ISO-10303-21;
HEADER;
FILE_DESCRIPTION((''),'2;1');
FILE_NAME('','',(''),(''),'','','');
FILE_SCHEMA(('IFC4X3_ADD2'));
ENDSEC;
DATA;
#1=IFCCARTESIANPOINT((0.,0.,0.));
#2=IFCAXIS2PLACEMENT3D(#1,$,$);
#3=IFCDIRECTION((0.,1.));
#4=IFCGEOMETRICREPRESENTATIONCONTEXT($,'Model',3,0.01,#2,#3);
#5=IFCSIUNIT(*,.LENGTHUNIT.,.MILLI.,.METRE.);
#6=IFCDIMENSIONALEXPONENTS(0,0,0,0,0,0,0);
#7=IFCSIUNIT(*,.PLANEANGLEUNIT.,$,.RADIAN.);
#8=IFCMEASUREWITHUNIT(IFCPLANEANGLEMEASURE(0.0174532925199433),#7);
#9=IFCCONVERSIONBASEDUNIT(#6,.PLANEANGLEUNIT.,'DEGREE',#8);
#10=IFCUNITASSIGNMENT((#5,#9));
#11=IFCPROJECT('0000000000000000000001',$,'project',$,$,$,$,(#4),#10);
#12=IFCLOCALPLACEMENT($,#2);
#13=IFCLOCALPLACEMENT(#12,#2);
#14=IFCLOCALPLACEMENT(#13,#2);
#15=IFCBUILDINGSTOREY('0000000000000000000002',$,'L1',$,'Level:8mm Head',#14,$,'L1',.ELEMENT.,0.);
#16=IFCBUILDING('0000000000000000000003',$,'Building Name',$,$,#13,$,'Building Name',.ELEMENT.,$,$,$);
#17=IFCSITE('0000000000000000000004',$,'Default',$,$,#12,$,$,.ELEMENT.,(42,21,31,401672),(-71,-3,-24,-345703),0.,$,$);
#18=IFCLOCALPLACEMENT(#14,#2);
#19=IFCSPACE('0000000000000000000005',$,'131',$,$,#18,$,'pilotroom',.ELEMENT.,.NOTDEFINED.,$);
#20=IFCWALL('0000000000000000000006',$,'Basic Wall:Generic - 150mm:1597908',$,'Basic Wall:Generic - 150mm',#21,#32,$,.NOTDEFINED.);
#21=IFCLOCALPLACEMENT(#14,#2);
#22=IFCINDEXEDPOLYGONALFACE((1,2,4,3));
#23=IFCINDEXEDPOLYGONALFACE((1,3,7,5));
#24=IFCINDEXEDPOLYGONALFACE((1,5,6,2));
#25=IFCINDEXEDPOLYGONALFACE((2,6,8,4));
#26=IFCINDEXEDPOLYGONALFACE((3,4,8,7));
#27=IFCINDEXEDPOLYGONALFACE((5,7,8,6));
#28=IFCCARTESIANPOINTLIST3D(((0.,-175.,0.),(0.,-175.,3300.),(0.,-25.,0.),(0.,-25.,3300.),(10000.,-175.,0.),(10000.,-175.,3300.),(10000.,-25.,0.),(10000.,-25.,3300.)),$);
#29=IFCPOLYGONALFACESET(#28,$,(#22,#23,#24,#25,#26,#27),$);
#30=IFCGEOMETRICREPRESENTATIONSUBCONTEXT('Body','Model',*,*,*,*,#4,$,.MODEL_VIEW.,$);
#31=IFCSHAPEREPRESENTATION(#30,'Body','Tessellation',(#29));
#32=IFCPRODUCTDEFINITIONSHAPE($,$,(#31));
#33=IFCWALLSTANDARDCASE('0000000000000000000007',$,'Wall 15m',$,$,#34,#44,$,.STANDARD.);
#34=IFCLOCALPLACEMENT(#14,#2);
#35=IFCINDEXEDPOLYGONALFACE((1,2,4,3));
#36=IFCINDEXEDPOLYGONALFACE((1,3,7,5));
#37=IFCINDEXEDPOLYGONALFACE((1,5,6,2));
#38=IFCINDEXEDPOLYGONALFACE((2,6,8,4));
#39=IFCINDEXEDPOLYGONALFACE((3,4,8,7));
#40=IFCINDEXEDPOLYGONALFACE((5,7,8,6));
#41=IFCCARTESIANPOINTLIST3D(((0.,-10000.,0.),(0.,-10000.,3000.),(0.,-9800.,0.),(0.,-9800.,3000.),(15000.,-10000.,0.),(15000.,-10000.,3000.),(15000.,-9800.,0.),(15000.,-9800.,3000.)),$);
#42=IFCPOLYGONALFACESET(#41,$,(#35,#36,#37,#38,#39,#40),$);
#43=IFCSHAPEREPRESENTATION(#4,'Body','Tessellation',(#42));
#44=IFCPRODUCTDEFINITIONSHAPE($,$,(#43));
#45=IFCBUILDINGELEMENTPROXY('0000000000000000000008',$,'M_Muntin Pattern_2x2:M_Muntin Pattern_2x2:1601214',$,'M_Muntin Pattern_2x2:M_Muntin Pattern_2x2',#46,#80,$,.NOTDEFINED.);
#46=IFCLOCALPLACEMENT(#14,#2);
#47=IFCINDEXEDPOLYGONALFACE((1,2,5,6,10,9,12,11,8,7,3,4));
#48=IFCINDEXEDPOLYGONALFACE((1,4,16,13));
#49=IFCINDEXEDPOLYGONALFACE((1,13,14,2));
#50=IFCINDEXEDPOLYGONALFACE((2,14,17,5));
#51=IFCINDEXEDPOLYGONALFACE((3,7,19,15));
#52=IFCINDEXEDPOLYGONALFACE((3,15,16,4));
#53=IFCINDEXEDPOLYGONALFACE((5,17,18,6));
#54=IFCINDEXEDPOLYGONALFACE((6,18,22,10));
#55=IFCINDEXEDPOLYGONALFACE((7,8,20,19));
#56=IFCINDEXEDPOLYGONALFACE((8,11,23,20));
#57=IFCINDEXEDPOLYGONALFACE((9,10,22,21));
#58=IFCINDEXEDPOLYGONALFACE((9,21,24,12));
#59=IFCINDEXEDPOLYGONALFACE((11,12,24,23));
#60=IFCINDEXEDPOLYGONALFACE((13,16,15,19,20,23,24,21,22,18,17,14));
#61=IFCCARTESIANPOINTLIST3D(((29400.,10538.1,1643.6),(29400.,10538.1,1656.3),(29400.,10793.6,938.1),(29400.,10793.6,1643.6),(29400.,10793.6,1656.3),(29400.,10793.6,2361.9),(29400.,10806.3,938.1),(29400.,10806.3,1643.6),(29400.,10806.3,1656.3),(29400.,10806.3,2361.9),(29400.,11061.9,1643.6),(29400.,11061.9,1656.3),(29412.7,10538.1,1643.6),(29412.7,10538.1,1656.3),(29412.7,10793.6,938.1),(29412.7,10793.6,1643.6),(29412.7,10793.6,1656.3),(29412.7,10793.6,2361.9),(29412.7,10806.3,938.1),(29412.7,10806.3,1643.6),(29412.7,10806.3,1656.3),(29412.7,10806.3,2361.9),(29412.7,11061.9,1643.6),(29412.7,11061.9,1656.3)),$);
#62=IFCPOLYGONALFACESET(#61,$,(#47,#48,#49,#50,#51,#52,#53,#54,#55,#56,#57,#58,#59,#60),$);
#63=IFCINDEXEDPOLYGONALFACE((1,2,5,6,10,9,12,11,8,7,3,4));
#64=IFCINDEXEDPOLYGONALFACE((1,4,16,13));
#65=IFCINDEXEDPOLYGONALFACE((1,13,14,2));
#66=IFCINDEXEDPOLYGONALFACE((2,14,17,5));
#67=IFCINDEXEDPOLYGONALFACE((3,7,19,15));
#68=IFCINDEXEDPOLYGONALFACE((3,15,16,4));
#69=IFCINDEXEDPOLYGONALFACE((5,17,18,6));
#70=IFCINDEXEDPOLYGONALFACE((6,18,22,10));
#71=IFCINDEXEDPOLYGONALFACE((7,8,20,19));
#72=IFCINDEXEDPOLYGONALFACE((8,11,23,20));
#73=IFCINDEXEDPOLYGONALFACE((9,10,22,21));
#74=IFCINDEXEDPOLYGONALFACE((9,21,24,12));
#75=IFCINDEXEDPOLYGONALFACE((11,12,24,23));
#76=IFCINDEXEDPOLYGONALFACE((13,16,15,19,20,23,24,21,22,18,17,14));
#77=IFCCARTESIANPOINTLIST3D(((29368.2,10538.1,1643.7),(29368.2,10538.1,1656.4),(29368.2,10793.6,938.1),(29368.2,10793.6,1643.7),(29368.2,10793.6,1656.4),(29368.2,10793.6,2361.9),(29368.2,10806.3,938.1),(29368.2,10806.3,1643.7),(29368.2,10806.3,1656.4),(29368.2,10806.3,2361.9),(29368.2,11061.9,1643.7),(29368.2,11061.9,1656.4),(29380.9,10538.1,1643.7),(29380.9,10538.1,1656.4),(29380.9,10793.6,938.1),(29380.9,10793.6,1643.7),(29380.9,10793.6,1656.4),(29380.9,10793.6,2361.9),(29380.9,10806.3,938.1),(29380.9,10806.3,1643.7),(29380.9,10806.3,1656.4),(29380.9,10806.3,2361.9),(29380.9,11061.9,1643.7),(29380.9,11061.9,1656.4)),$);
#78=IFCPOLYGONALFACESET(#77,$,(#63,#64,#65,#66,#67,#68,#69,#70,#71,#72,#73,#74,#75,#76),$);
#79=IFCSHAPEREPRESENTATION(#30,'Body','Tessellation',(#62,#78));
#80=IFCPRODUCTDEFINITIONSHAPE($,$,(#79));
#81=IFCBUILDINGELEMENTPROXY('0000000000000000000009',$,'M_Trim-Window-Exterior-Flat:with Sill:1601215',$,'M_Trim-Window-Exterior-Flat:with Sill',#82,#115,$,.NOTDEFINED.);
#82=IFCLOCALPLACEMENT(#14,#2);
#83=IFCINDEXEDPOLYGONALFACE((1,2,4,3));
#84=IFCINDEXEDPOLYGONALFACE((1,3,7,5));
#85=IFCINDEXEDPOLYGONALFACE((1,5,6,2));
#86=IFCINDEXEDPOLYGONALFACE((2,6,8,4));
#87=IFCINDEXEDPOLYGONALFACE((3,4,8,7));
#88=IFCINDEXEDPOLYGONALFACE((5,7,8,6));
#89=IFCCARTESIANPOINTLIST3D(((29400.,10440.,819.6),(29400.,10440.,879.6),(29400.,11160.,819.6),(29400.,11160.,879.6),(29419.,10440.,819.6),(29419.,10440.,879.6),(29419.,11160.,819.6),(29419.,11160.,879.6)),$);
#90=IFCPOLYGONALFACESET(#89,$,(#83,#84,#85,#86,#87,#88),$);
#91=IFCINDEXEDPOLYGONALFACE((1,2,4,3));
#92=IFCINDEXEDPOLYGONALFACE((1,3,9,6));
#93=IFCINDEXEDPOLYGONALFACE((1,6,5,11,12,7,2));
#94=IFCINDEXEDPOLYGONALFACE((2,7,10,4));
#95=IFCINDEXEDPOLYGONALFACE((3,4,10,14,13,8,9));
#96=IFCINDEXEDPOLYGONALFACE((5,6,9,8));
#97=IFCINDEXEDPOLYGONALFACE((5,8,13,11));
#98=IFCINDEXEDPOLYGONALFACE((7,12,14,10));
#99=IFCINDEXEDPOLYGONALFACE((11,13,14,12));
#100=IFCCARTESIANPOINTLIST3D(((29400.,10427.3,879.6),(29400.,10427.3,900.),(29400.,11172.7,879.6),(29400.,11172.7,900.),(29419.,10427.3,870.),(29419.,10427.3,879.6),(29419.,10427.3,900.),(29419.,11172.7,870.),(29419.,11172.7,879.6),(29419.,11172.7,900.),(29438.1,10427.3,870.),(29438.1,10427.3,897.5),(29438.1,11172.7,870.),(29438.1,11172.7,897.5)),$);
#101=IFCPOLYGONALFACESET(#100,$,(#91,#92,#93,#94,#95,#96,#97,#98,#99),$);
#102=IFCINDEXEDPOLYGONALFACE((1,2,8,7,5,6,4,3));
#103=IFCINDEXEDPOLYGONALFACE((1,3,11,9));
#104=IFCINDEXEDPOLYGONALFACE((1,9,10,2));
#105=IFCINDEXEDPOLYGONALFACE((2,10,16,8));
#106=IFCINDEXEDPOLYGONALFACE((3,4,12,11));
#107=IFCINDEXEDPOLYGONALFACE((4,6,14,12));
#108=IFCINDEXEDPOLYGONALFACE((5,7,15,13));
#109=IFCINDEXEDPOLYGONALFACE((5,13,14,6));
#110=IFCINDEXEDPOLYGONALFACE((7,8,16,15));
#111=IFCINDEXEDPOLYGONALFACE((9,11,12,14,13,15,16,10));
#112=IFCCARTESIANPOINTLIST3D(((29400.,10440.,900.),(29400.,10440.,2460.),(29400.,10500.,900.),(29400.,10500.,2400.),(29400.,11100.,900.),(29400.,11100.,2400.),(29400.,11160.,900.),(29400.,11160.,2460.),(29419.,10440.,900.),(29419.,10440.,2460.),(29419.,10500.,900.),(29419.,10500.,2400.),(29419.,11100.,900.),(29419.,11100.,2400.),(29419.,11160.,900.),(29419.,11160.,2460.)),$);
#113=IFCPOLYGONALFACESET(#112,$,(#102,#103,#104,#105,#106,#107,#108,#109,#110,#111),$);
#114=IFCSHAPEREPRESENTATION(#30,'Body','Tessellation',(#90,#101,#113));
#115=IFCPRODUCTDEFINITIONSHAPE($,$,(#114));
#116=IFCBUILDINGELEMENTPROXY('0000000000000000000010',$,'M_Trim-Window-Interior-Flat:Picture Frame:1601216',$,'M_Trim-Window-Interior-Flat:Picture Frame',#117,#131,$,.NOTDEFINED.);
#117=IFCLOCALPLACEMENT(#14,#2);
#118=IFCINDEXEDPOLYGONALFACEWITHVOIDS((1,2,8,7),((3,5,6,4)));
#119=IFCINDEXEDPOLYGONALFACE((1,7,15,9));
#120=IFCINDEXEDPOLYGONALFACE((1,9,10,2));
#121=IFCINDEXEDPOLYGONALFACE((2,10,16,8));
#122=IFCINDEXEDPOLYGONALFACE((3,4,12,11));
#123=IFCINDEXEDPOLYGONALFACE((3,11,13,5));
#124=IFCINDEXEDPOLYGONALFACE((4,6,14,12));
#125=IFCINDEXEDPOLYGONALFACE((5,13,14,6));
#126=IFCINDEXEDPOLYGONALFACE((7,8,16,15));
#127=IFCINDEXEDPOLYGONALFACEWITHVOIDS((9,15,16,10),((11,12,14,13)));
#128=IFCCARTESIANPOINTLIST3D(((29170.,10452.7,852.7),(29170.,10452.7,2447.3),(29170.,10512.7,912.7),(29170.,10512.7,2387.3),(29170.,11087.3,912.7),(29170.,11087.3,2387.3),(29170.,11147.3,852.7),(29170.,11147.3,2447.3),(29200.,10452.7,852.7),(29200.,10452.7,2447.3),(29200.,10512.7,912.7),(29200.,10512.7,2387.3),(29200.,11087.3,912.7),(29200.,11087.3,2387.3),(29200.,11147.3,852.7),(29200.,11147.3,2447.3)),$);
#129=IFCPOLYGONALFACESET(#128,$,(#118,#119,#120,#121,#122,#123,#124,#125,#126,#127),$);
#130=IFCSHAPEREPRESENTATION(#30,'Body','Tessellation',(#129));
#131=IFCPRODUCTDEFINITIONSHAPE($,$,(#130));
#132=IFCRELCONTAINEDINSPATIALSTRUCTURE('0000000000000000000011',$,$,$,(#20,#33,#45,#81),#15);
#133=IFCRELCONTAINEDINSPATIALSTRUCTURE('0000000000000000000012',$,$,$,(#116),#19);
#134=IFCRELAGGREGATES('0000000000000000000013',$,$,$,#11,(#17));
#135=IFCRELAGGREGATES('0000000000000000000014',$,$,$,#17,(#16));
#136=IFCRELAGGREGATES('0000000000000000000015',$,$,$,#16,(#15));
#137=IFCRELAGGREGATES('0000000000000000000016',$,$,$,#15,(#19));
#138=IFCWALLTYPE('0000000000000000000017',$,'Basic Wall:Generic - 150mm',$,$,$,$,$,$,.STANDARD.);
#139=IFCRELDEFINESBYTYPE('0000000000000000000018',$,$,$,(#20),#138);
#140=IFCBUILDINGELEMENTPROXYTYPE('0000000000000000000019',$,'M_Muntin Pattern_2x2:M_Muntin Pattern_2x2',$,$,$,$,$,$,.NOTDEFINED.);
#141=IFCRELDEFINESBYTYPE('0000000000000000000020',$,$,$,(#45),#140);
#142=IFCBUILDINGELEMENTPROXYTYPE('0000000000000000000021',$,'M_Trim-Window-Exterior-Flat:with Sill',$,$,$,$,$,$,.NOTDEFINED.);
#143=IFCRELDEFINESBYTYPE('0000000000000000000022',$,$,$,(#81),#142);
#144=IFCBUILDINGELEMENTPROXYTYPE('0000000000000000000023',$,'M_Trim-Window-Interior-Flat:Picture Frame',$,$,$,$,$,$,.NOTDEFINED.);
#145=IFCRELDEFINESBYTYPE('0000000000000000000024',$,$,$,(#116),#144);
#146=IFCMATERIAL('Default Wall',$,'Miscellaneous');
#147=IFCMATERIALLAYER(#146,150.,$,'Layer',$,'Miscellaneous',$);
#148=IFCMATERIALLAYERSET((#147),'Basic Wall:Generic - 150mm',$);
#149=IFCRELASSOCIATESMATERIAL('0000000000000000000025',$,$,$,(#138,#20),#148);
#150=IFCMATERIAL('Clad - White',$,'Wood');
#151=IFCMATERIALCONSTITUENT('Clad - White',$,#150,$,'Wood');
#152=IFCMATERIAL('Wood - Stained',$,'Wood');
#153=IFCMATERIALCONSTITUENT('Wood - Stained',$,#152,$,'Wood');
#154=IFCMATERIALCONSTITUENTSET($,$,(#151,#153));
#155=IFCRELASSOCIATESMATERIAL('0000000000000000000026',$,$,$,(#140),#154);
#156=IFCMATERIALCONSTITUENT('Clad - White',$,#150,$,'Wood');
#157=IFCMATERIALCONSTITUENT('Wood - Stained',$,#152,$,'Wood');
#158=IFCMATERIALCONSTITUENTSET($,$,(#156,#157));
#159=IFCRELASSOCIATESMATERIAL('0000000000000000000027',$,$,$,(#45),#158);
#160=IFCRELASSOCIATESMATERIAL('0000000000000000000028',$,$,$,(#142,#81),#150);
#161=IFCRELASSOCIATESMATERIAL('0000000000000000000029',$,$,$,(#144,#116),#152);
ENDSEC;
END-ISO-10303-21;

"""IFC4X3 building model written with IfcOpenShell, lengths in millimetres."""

from ifc_helpers import new_model, entity, si_unit, converted_unit, direction, frame, frame_2d, origin, origin_with_axes, place, context, subcontext, project, spatial, polyline, indexed_curve, rectangle, outline, extrude, shape, source, transform, mapped, material, layer, layer_set, constituent, constituent_set, type_object, type_shapes, element, save


model = new_model("IFC4X3")

# Units and contexts
model_context = context("Model", 3, precision=0.01, world=origin(), true_north=direction((0.0, 1.0)))
body_context = subcontext(model_context, "Body", "Model", "MODEL_VIEW")
ifc_project = project(units=[si_unit("LENGTHUNIT", "METRE", prefix="MILLI"), converted_unit("PLANEANGLEUNIT", "DEGREE", entity("IfcPlaneAngleMeasure", 0.0174532925199433), si_unit("PLANEANGLEUNIT", "RADIAN"), dimensions=[0, 0, 0, 0, 0, 0, 0])], contexts=[model_context])

# Site, building, storey
site_placement = place(None, origin())
site = spatial("IfcSite", under=ifc_project, at=site_placement, Name="Default", CompositionType="ELEMENT", RefLatitude=(42, 21, 31, 401672), RefLongitude=(-71, -3, -24, -345703), RefElevation=0.0)
building_placement = place(site_placement, origin())
building = spatial("IfcBuilding", under=site, at=building_placement, Name="Building Name", LongName="Building Name", CompositionType="ELEMENT")
storey_placement = place(building_placement, origin())
storey = spatial("IfcBuildingStorey", under=building, at=storey_placement, Name="L1", ObjectType="Level:8mm Head", LongName="L1", CompositionType="ELEMENT", Elevation=0.0)

# Shared definitions
ifc_material_1 = material(Name="Default Wall", Category="Miscellaneous")

# Walls
ifc_layer_1 = layer(ifc_material_1, 150.0, Name="Layer", Category="Miscellaneous")
ifc_layer_set_1 = layer_set([ifc_layer_1], Name="Basic Wall:Generic - 150mm")
wall_type_1 = type_object("IfcWallType", Name="Basic Wall:Generic - 150mm", PredefinedType="STANDARD", material=ifc_layer_set_1)
wall_1_placement = place(storey_placement, frame((0.0, -100.0, 0.0)))
element("IfcWall", 1, at=wall_1_placement, inside=storey, type_object=wall_type_1, material=ifc_layer_set_1, Name="Basic Wall:Generic - 150mm:1597908", ObjectType="Basic Wall:Generic - 150mm", PredefinedType="NOTDEFINED", context=body_context, shape_type="SweptSolid", body=[
    extrude(rectangle(XDim=10000.0, YDim=150.0, at=frame_2d((5000.0, 0.0), x_axis=(-1.0, 0.0))), origin(), (0.0, 0.0, 1.0), 3300.0),
])
wall_2_placement = place(storey_placement, frame((0.0, -10000.0, 0.0), z_axis=(0.0, 0.0, 1.0), x_axis=(1.0, 0.0, 0.0)))
element("IfcWallStandardCase", 2, at=wall_2_placement, inside=storey, Name="Wall 15m", PredefinedType="STANDARD", shapes=[
    shape(model_context, None, "SweptSolid", [extrude(outline(indexed_curve([(0.0, 0.0), (0.0, 200.0), (15000.0, 200.0), (15000.0, 0.0), (0.0, 0.0)], self_intersect=False)), origin_with_axes(), (0.0, 0.0, 1.0), 3000.0)]),
])

# Building element proxies
ifc_material_2 = material(Name="Clad - White", Category="Wood")
ifc_constituent_1 = constituent(ifc_material_2, Name="Clad - White", Category="Wood")
ifc_material_3 = material(Name="Wood - Stained", Category="Wood")
ifc_constituent_2 = constituent(ifc_material_3, Name="Wood - Stained", Category="Wood")
ifc_constituent_set_1 = constituent_set(constituents=[ifc_constituent_1, ifc_constituent_2])
ifc_constituent_3 = constituent(ifc_material_2, Name="Clad - White", Category="Wood")
ifc_constituent_4 = constituent(ifc_material_3, Name="Wood - Stained", Category="Wood")
ifc_constituent_set_2 = constituent_set(constituents=[ifc_constituent_3, ifc_constituent_4])
building_element_proxy_type_1 = type_object("IfcBuildingElementProxyType", Name="M_Muntin Pattern_2x2:M_Muntin Pattern_2x2", PredefinedType="NOTDEFINED", material=ifc_constituent_set_2)
shared_shape_1 = source(origin(), body_context, "Body", "SweptSolid", [
    extrude(outline(polyline([(6.4, -6.4), (711.9, -6.4), (711.9, 6.3), (6.4, 6.3), (6.4, 261.9), (-6.3, 261.9), (-6.3, 6.3), (-711.9, 6.3), (-711.9, -6.4), (-6.3, -6.4), (-6.3, -261.9), (6.4, -261.9), (6.4, -6.4)])), frame((0.0, -22.2, 711.9), z_axis=(0.0, 1.0, 0.0), x_axis=(0.0, 0.0, 1.0)), (0.0, 0.0, 1.0), 12.7),
    extrude(outline(polyline([(6.4, -6.4), (711.9, -6.4), (711.9, 6.3), (6.4, 6.3), (6.4, 261.9), (-6.3, 261.9), (-6.3, 6.3), (-711.9, 6.3), (-711.9, -6.4), (-6.3, -6.4), (-6.3, -261.9), (6.4, -261.9), (6.4, -6.4)])), frame((0.0, 9.5, 711.9), z_axis=(0.0, 1.0, 0.0), x_axis=(0.0, 0.0, 1.0)), (0.0, 0.0, 1.0), 12.7),
])
type_shapes(building_element_proxy_type_1, [shared_shape_1])
proxy_1_placement = place(storey_placement, frame((29390.5, 10800.0, 938.1), z_axis=(0.0, 0.0, 1.0), x_axis=(0.0, 1.0, 0.0)))
element("IfcBuildingElementProxy", 3, at=proxy_1_placement, inside=storey, type_object=building_element_proxy_type_1, material=ifc_constituent_set_1, Name="M_Muntin Pattern_2x2:M_Muntin Pattern_2x2:1601214", ObjectType="M_Muntin Pattern_2x2:M_Muntin Pattern_2x2", PredefinedType="NOTDEFINED", context=body_context, shape_type="MappedRepresentation", body=[
    mapped(shared_shape_1, transform((0.0, 0.0, 0.0), scale=1.0)),
])
building_element_proxy_type_2 = type_object("IfcBuildingElementProxyType", Name="M_Trim-Window-Exterior-Flat:with Sill", PredefinedType="NOTDEFINED", material=ifc_material_2)
shared_shape_2 = source(origin(), body_context, "Body", "SweptSolid", [
    extrude(rectangle(XDim=720.0, YDim=60.0, at=frame_2d((0.0, 0.0), x_axis=(1.0, 0.0))), frame((0.0, -1550.4, 0.0), z_axis=(0.0, 0.0, 1.0), x_axis=(-1.0, 0.0, 0.0)), (0.0, 0.0, 1.0), 19.1),
    extrude(outline(polyline([(-19.0, -15.2), (0.0, -15.2), (0.0, -5.7), (19.0, -5.7), (19.0, 14.8), (0.0, 14.8), (-19.0, 12.3), (-19.0, -15.2)])), frame((-372.7, -1514.8, 19.0), z_axis=(1.0, 0.0, 0.0), x_axis=(0.0, 0.0, -1.0)), (0.0, 0.0, 1.0), 745.4),
    extrude(outline(polyline([(-795.0, -360.0), (765.0, -360.0), (765.0, -300.0), (-735.0, -300.0), (-735.0, 300.0), (765.0, 300.0), (765.0, 360.0), (-795.0, 360.0), (-795.0, -360.0)])), frame((0.0, -735.0, 0.0), z_axis=(0.0, 0.0, 1.0), x_axis=(0.0, -1.0, 0.0)), (0.0, 0.0, 1.0), 19.1),
])
type_shapes(building_element_proxy_type_2, [shared_shape_2])
proxy_2_placement = place(storey_placement, frame((29400.0, 10800.0, 2400.0), z_axis=(1.0, 0.0, 0.0), x_axis=(0.0, 1.0, 0.0)))
element("IfcBuildingElementProxy", 4, at=proxy_2_placement, inside=storey, type_object=building_element_proxy_type_2, material=ifc_material_2, Name="M_Trim-Window-Exterior-Flat:with Sill:1601215", ObjectType="M_Trim-Window-Exterior-Flat:with Sill", PredefinedType="NOTDEFINED", context=body_context, shape_type="MappedRepresentation", body=[
    mapped(shared_shape_2, transform((0.0, 0.0, 0.0), scale=1.0)),
])

# Shared definitions
space_placement = place(storey_placement, origin())
space = spatial("IfcSpace", under=storey, at=space_placement, Name="131", LongName="pilotroom", CompositionType="ELEMENT", PredefinedType="NOTDEFINED")

# Building element proxy
building_element_proxy_type_3 = type_object("IfcBuildingElementProxyType", Name="M_Trim-Window-Interior-Flat:Picture Frame", PredefinedType="NOTDEFINED", material=ifc_material_3)
shared_shape_3 = source(origin(), body_context, "Body", "SweptSolid", [
    extrude(outline(polyline([(-347.3, -797.3), (347.3, -797.3), (347.3, 797.3), (-347.3, 797.3), (-347.3, -797.3)]), holes=[polyline([(-287.3, -737.3), (-287.3, 737.3), (287.3, 737.3), (287.3, -737.3), (-287.3, -737.3)])]), frame((0.0, -750.0, 0.0), z_axis=(0.0, 0.0, 1.0), x_axis=(-1.0, 0.0, 0.0)), (0.0, 0.0, 1.0), 30.0),
])
type_shapes(building_element_proxy_type_3, [shared_shape_3])
proxy_3_placement = place(space_placement, frame((29200.0, 10800.0, 2400.0), z_axis=(-1.0, 0.0, 0.0), x_axis=(0.0, -1.0, 0.0)))
element("IfcBuildingElementProxy", 5, at=proxy_3_placement, inside=space, type_object=building_element_proxy_type_3, material=ifc_material_3, Name="M_Trim-Window-Interior-Flat:Picture Frame:1601216", ObjectType="M_Trim-Window-Interior-Flat:Picture Frame", PredefinedType="NOTDEFINED", context=body_context, shape_type="MappedRepresentation", body=[
    mapped(shared_shape_3, transform((0.0, 0.0, 0.0), scale=1.0)),
])

save(model, "model.ifc")
